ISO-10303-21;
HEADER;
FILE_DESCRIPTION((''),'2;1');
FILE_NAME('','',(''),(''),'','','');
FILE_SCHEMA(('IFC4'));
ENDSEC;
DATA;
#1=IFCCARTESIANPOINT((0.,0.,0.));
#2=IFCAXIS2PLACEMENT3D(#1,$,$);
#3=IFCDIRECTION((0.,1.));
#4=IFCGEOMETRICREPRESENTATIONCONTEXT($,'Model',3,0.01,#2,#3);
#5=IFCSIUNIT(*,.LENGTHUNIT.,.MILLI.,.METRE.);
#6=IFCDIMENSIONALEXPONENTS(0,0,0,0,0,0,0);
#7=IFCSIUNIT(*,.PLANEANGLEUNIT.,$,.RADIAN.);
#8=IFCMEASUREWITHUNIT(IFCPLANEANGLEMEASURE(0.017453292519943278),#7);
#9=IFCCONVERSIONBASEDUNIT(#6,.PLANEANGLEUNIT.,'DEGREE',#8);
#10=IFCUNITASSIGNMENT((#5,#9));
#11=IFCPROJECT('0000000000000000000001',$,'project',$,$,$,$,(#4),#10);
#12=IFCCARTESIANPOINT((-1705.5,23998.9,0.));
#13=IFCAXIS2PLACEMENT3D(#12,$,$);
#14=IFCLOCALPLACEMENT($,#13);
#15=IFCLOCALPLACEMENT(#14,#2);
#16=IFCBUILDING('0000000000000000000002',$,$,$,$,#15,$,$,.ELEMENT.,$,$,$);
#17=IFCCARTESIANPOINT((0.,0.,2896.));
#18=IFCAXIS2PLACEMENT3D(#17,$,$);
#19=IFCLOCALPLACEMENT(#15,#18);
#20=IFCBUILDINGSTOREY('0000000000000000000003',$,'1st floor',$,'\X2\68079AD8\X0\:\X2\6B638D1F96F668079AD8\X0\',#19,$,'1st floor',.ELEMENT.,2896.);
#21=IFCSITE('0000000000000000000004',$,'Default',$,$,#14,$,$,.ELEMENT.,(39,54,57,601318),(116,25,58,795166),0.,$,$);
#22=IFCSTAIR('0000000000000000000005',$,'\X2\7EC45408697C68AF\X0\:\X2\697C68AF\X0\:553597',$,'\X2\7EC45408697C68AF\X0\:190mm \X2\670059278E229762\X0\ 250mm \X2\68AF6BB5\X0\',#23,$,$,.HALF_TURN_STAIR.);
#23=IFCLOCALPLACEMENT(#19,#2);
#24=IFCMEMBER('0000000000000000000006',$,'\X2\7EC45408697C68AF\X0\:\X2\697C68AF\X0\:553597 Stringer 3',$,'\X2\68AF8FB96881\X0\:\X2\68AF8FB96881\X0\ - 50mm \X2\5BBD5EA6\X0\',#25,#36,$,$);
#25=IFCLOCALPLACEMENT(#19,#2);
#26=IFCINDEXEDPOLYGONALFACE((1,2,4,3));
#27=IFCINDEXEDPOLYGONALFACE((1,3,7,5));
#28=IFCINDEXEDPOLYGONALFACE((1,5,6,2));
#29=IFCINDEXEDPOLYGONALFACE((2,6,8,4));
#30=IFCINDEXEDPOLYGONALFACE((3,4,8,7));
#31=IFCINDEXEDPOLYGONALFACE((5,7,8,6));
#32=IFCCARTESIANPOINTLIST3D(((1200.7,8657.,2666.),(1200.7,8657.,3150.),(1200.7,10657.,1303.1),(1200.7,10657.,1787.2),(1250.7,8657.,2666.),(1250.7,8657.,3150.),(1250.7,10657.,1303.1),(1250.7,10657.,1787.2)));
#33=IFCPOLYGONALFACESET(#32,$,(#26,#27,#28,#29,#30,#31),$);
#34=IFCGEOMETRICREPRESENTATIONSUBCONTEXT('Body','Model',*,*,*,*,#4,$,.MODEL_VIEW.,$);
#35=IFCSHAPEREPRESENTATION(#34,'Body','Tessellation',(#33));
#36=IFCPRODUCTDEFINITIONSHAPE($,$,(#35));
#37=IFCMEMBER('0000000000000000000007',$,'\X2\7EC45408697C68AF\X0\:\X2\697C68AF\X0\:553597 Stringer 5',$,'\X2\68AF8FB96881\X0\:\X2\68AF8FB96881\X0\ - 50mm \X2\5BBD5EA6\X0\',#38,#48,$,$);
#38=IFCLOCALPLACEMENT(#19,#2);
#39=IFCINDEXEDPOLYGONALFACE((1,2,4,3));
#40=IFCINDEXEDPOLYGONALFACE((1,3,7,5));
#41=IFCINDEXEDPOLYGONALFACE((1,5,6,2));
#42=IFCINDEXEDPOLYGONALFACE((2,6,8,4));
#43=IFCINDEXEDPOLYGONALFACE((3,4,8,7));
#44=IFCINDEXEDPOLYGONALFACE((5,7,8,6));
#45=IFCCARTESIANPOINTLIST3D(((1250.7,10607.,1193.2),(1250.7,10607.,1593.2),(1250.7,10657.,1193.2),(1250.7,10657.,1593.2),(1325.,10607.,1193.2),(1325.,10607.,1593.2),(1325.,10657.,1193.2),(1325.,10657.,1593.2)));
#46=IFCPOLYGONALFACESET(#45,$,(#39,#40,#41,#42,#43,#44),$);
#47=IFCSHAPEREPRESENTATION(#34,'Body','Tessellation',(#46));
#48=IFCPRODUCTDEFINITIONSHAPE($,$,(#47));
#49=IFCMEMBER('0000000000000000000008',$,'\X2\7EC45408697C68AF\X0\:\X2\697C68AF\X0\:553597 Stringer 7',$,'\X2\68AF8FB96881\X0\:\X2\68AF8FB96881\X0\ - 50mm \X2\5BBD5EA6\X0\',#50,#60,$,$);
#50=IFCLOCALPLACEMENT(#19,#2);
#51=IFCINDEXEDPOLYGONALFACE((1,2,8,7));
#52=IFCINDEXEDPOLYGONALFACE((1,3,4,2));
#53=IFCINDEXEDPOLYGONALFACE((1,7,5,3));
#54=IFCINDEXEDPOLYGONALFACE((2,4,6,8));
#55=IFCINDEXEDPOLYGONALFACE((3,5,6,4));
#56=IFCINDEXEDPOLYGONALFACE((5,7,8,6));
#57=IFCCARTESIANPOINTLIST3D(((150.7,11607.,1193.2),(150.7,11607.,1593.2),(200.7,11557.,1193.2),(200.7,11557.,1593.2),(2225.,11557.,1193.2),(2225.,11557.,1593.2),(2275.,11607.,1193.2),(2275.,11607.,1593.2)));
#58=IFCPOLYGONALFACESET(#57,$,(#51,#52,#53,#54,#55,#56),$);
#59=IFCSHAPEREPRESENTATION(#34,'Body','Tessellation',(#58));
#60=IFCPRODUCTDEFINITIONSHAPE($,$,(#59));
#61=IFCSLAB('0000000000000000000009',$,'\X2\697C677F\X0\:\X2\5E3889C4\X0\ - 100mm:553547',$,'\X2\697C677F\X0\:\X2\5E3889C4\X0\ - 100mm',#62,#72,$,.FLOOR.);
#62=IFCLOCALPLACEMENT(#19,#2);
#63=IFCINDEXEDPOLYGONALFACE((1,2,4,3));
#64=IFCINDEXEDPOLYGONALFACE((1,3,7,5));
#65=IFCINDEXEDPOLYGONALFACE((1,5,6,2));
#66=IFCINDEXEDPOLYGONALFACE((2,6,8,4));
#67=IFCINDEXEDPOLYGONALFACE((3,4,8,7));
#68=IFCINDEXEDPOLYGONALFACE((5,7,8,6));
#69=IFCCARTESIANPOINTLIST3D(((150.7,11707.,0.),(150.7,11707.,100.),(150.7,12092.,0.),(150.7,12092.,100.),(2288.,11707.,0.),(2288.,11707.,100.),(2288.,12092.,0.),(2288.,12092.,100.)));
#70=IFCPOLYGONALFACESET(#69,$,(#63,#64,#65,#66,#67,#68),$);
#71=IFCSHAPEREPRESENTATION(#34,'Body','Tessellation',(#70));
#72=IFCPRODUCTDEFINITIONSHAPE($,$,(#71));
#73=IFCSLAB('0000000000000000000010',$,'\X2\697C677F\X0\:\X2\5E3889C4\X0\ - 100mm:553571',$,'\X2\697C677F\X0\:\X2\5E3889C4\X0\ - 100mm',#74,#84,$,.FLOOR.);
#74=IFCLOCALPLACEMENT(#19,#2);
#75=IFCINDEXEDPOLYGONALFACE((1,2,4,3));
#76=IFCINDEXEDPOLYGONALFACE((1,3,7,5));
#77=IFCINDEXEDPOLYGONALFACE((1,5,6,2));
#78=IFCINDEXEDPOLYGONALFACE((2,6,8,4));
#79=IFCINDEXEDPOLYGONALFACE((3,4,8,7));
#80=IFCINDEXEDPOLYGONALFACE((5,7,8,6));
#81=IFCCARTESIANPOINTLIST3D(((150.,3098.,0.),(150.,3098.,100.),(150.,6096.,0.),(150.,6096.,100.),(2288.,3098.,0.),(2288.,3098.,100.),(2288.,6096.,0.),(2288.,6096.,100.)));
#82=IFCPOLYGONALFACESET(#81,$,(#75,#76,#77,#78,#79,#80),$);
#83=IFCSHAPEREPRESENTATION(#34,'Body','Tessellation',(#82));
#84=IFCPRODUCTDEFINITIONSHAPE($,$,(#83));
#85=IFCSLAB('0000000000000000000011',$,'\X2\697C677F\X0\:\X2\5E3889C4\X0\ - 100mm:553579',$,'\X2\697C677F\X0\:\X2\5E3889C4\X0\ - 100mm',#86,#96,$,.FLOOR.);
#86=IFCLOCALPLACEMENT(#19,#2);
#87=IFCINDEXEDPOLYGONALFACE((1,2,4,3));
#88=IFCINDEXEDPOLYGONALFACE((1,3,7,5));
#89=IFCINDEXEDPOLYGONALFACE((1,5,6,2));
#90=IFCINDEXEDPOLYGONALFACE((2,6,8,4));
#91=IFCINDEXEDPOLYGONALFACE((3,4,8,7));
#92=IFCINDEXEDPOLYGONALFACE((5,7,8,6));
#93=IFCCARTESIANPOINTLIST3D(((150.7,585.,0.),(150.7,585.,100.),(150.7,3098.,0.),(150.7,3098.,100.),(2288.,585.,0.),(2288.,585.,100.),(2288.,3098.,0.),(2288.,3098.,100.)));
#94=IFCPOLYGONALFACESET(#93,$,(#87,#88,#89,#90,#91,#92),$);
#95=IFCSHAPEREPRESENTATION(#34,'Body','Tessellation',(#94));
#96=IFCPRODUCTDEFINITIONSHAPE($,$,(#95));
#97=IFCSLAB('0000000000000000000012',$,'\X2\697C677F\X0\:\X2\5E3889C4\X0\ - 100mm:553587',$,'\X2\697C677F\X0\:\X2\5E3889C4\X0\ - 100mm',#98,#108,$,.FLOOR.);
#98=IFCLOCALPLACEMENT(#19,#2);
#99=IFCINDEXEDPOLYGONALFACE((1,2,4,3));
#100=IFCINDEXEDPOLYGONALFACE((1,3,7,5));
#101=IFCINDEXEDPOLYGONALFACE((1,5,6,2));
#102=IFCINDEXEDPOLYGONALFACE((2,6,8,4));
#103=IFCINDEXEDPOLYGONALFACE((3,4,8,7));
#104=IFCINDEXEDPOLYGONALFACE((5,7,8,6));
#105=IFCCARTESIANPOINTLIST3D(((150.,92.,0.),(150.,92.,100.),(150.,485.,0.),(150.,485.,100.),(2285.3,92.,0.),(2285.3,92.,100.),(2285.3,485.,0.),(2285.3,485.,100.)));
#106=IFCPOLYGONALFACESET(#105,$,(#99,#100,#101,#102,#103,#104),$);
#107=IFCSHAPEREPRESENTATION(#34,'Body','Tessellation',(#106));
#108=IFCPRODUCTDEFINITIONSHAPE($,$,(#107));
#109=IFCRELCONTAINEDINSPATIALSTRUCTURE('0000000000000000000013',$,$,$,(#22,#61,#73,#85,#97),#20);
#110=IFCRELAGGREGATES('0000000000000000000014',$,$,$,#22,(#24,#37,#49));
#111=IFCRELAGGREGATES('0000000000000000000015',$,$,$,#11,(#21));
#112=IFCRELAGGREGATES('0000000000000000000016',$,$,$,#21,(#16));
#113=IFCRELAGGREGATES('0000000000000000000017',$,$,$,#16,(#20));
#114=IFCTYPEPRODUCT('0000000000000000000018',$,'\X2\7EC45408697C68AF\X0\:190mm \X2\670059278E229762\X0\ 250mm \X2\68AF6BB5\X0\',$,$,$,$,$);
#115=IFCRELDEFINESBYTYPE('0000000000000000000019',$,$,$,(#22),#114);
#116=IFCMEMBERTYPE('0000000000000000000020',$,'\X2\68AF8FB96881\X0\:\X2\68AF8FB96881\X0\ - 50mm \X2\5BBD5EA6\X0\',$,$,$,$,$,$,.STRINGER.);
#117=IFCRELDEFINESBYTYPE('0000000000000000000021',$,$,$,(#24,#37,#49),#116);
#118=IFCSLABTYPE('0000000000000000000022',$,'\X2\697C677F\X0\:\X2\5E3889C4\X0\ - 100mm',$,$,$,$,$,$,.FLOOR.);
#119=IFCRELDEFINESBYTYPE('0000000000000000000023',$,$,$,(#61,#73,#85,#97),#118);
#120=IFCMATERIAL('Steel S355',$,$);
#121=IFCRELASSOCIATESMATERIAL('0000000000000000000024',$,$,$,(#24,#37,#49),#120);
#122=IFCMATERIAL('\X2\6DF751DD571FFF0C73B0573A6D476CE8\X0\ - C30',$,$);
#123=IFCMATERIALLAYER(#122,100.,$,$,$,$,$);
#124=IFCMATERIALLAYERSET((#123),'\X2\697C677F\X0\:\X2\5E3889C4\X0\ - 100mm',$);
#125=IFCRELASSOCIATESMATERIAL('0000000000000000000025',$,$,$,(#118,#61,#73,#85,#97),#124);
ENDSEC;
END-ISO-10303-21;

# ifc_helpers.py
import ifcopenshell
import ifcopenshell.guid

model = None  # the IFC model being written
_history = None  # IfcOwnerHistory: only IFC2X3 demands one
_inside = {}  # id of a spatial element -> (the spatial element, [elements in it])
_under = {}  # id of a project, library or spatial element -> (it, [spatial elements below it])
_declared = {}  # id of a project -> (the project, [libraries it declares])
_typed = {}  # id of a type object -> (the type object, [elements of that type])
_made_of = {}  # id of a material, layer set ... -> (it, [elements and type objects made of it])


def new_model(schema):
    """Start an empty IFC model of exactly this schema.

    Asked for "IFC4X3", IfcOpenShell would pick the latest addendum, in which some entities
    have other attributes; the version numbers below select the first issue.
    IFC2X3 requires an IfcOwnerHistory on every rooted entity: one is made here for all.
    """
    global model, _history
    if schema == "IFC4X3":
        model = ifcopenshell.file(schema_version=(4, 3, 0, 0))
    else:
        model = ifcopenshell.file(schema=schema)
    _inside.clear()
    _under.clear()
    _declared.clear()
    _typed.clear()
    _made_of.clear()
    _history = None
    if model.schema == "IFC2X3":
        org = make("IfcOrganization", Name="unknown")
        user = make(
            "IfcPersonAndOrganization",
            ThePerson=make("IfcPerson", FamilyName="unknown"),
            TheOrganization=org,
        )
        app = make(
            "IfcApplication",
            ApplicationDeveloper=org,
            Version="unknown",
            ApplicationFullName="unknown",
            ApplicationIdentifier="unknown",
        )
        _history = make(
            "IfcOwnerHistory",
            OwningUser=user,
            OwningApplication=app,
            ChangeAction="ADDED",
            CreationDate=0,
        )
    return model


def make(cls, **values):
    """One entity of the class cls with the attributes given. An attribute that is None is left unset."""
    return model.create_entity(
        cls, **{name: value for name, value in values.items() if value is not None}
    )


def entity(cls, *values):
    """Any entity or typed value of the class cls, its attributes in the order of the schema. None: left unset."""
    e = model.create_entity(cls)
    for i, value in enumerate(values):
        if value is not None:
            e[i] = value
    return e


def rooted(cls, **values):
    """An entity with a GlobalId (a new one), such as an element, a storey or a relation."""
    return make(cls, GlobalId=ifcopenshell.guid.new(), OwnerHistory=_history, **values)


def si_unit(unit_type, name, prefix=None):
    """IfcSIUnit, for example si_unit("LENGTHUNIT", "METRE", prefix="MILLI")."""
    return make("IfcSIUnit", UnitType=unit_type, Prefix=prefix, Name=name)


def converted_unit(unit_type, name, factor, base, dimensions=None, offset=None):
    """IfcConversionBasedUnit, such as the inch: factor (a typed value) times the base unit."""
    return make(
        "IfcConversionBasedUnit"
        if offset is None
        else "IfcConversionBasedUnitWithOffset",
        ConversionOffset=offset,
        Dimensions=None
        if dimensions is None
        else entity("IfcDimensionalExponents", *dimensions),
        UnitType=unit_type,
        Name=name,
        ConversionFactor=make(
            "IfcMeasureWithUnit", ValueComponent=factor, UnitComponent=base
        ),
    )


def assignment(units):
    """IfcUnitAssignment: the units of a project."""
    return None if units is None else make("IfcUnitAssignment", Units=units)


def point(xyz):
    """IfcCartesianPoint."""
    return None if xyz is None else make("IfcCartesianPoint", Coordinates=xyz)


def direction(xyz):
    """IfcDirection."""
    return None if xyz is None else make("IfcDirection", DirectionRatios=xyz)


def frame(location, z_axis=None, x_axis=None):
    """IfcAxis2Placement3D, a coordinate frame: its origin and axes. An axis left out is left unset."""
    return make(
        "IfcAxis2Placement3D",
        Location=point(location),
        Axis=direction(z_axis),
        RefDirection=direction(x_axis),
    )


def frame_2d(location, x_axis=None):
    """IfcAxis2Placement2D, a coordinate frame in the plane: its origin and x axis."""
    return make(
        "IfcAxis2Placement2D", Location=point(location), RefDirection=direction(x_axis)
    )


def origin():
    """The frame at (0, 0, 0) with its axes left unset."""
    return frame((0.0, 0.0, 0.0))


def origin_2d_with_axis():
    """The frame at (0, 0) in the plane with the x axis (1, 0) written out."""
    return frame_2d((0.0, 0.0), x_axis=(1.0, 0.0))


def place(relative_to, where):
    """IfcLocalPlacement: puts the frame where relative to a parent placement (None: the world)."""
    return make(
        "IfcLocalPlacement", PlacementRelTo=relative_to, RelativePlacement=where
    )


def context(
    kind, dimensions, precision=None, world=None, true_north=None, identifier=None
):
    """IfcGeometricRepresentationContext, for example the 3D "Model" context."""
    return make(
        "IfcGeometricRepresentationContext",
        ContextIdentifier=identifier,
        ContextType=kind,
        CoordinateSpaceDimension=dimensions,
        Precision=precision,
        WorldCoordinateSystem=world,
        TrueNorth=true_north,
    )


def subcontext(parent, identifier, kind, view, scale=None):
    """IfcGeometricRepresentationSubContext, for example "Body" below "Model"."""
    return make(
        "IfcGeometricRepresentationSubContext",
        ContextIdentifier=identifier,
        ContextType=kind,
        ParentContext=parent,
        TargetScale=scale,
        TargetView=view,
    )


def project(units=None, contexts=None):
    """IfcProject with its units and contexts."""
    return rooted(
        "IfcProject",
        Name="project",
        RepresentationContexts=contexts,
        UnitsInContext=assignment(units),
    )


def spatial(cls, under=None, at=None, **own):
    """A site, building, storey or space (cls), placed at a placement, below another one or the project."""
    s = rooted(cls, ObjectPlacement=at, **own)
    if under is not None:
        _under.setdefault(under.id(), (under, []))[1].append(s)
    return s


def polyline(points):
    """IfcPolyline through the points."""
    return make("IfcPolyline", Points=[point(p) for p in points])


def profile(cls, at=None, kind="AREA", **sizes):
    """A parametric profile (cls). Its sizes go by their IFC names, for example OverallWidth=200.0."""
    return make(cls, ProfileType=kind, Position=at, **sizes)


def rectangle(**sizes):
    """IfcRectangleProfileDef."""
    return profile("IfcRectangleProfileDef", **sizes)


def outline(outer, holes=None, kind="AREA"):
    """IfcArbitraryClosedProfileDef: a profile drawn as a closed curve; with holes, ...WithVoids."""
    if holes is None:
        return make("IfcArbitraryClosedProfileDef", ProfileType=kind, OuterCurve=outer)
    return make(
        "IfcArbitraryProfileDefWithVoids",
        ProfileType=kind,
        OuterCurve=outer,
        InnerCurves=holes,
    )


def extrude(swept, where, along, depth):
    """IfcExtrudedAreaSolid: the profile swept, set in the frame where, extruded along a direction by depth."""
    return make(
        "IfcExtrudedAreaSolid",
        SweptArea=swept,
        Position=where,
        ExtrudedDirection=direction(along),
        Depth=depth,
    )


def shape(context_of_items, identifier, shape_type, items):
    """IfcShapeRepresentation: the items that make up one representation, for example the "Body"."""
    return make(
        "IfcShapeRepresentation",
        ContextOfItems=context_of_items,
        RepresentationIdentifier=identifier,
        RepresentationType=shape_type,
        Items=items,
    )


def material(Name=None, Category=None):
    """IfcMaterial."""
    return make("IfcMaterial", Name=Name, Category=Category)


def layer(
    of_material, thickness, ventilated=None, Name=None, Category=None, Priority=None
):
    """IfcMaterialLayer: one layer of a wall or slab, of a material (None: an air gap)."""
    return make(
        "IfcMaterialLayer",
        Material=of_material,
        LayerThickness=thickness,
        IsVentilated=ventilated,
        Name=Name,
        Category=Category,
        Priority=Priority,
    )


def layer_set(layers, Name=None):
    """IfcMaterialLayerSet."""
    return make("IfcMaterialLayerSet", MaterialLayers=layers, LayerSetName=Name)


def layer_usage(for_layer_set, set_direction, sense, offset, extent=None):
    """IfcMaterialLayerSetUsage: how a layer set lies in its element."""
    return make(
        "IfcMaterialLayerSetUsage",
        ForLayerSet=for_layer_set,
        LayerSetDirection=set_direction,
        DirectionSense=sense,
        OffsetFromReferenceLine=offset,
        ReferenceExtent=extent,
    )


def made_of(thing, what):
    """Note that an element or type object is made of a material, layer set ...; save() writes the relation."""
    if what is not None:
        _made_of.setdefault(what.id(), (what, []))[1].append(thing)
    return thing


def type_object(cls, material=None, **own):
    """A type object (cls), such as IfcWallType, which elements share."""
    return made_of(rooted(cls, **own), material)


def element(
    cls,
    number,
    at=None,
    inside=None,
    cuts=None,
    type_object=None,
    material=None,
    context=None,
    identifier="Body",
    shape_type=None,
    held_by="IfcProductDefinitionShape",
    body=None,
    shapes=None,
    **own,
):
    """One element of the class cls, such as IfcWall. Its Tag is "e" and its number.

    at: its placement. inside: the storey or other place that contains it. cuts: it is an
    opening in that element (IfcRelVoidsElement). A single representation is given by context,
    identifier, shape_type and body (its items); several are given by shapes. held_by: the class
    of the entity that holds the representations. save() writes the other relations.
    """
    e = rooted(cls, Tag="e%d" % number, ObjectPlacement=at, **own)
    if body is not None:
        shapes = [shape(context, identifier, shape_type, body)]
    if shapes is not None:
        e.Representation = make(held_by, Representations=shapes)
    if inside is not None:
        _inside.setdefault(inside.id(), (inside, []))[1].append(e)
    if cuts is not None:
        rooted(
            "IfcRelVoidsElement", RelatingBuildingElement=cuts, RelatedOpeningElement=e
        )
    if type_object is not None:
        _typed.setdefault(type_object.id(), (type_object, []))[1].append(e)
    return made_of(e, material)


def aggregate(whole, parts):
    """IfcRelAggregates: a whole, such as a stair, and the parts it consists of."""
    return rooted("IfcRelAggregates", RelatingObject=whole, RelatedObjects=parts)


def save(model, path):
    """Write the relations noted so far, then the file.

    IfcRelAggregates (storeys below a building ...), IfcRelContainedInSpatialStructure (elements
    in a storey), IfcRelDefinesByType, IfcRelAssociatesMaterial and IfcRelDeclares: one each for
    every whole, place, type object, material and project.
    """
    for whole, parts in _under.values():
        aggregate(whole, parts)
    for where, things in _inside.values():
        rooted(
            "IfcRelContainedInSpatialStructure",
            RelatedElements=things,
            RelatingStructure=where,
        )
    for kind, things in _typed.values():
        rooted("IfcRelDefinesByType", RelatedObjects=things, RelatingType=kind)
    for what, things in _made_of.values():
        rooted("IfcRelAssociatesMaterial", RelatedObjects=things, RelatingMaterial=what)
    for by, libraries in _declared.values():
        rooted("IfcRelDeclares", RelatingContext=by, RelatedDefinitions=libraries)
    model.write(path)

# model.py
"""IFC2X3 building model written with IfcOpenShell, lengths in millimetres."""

from ifc_helpers import new_model, entity, si_unit, converted_unit, direction, frame, frame_2d, origin, origin_2d_with_axis, place, context, subcontext, project, spatial, polyline, rectangle, outline, extrude, material, layer, layer_set, layer_usage, type_object, element, aggregate, save


model = new_model("IFC2X3")

# Units and contexts
model_context = context("Model", 3, precision=0.01, world=origin(), true_north=direction((0.0, 1.0)))
body_context = subcontext(model_context, "Body", "Model", "MODEL_VIEW")
ifc_project = project(units=[si_unit("LENGTHUNIT", "METRE", prefix="MILLI"), converted_unit("PLANEANGLEUNIT", "DEGREE", entity("IfcPlaneAngleMeasure", 0.017453292519943278), si_unit("PLANEANGLEUNIT", "RADIAN"), dimensions=[0, 0, 0, 0, 0, 0, 0])], contexts=[model_context])

# Site, building, storey
site_placement = place(None, frame((-1705.5, 23998.9, 0.0)))
site = spatial("IfcSite", under=ifc_project, at=site_placement, Name="Default", CompositionType="ELEMENT", RefLatitude=(39, 54, 57, 601318), RefLongitude=(116, 25, 58, 795166), RefElevation=0.0)
building_placement = place(site_placement, origin())
building = spatial("IfcBuilding", under=site, at=building_placement, CompositionType="ELEMENT")
storey_placement = place(building_placement, frame((0.0, 0.0, 2896.0)))
storey = spatial("IfcBuildingStorey", under=building, at=storey_placement, Name="1st floor", ObjectType="标高:正负零标高", LongName="1st floor", CompositionType="ELEMENT", Elevation=2896.0)

# Stair, members
type_product = type_object("IfcTypeProduct", Name="组合楼梯:190mm 最大踢面 250mm 梯段")
stair_placement = place(storey_placement, origin())
stair = element("IfcStair", 1, at=stair_placement, inside=storey, type_object=type_product, Name="组合楼梯:楼梯:553597", ObjectType="组合楼梯:190mm 最大踢面 250mm 梯段", ShapeType="HALF_TURN_STAIR")
ifc_material_1 = material(Name="Steel S355")
member_type = type_object("IfcMemberType", Name="梯边梁:梯边梁 - 50mm 宽度", PredefinedType="STRINGER")
member_1_placement = place(stair_placement, origin())
member_1 = element("IfcMember", 2, at=member_1_placement, type_object=member_type, material=ifc_material_1, Name="组合楼梯:楼梯:553597 Stringer 3", ObjectType="梯边梁:梯边梁 - 50mm 宽度", context=body_context, shape_type="SweptSolid", body=[
    extrude(outline(polyline([(-1073.8, -200.0), (1346.4, -200.0), (1073.8, 200.0), (-1346.4, 200.0), (-1073.8, -200.0)])), frame((1200.7, 9657.0, 2226.6), z_axis=(1.0, 0.0, 0.0), x_axis=(0.0, -0.826384, 0.563108)), (0.0, 0.0, 1.0), 50.0),
])
member_2_placement = place(stair_placement, origin())
member_2 = element("IfcMember", 3, at=member_2_placement, type_object=member_type, material=ifc_material_1, Name="组合楼梯:楼梯:553597 Stringer 5", ObjectType="梯边梁:梯边梁 - 50mm 宽度", context=body_context, shape_type="SweptSolid", body=[
    extrude(rectangle(XDim=74.3, YDim=50.0, at=frame_2d((0.0, 0.0), x_axis=(1.0, 0.0))), frame((1287.9, 10632.0, 1193.2)), (0.0, 0.0, 1.0), 400.0),
])
member_3_placement = place(stair_placement, origin())
member_3 = element("IfcMember", 4, at=member_3_placement, type_object=member_type, material=ifc_material_1, Name="组合楼梯:楼梯:553597 Stringer 7", ObjectType="梯边梁:梯边梁 - 50mm 宽度", context=body_context, shape_type="SweptSolid", body=[
    extrude(outline(polyline([(-1062.2, -25.0), (1062.2, -25.0), (1012.2, 25.0), (-1012.2, 25.0), (-1062.2, -25.0)])), frame((1212.8, 11582.0, 1193.2), z_axis=(0.0, 0.0, 1.0), x_axis=(-1.0, 0.0, 0.0)), (0.0, 0.0, 1.0), 400.0),
])

# Slabs
ifc_material_2 = material(Name="混凝土，现场浇注 - C30")
ifc_layer_1 = layer(ifc_material_2, 100.0)
ifc_layer_set_1 = layer_set([ifc_layer_1], Name="楼板:常规 - 100mm")
ifc_layer_usage_1 = layer_usage(ifc_layer_set_1, "AXIS3", "POSITIVE", 0.0)
slab_type_1 = type_object("IfcSlabType", Name="楼板:常规 - 100mm", PredefinedType="FLOOR", material=ifc_layer_set_1)
slab_1_placement = place(storey_placement, origin())
element("IfcSlab", 5, at=slab_1_placement, inside=storey, type_object=slab_type_1, material=ifc_layer_usage_1, Name="楼板:常规 - 100mm:553547", ObjectType="楼板:常规 - 100mm", PredefinedType="FLOOR", context=body_context, shape_type="SweptSolid", body=[
    extrude(rectangle(XDim=385.0, YDim=2137.3, at=origin_2d_with_axis()), frame((1219.3, 11899.5, 100.0), z_axis=(0.0, 0.0, -1.0), x_axis=(0.0, 1.0, 0.0)), (0.0, 0.0, 1.0), 100.0),
])
ifc_layer_usage_2 = layer_usage(ifc_layer_set_1, "AXIS3", "POSITIVE", 0.0)
slab_2_placement = place(storey_placement, origin())
element("IfcSlab", 6, at=slab_2_placement, inside=storey, type_object=slab_type_1, material=ifc_layer_usage_2, Name="楼板:常规 - 100mm:553571", ObjectType="楼板:常规 - 100mm", PredefinedType="FLOOR", context=body_context, shape_type="SweptSolid", body=[
    extrude(rectangle(XDim=2998.0, YDim=2138.0, at=frame_2d((0.0, 0.0), x_axis=(1.0, 0.0))), frame((1219.0, 4597.0, 100.0), z_axis=(0.0, 0.0, -1.0), x_axis=(0.0, 1.0, 0.0)), (0.0, 0.0, 1.0), 100.0),
])
ifc_layer_usage_3 = layer_usage(ifc_layer_set_1, "AXIS3", "POSITIVE", 0.0)
slab_3_placement = place(storey_placement, origin())
element("IfcSlab", 7, at=slab_3_placement, inside=storey, type_object=slab_type_1, material=ifc_layer_usage_3, Name="楼板:常规 - 100mm:553579", ObjectType="楼板:常规 - 100mm", PredefinedType="FLOOR", context=body_context, shape_type="SweptSolid", body=[
    extrude(rectangle(XDim=2513.0, YDim=2137.3, at=frame_2d((0.0, 0.0), x_axis=(1.0, 0.0))), frame((1219.3, 1841.5, 100.0), z_axis=(0.0, 0.0, -1.0), x_axis=(0.0, 1.0, 0.0)), (0.0, 0.0, 1.0), 100.0),
])
ifc_layer_usage_4 = layer_usage(ifc_layer_set_1, "AXIS3", "POSITIVE", 0.0)
slab_4_placement = place(storey_placement, origin())
element("IfcSlab", 8, at=slab_4_placement, inside=storey, type_object=slab_type_1, material=ifc_layer_usage_4, Name="楼板:常规 - 100mm:553587", ObjectType="楼板:常规 - 100mm", PredefinedType="FLOOR", context=body_context, shape_type="SweptSolid", body=[
    extrude(rectangle(XDim=393.0, YDim=2135.3, at=frame_2d((0.0, 0.0), x_axis=(1.0, 0.0))), frame((1217.7, 288.5, 100.0), z_axis=(0.0, 0.0, -1.0), x_axis=(0.0, 1.0, 0.0)), (0.0, 0.0, 1.0), 100.0),
])

aggregate(stair, [member_1, member_2, member_3])

save(model, "model.ifc")
